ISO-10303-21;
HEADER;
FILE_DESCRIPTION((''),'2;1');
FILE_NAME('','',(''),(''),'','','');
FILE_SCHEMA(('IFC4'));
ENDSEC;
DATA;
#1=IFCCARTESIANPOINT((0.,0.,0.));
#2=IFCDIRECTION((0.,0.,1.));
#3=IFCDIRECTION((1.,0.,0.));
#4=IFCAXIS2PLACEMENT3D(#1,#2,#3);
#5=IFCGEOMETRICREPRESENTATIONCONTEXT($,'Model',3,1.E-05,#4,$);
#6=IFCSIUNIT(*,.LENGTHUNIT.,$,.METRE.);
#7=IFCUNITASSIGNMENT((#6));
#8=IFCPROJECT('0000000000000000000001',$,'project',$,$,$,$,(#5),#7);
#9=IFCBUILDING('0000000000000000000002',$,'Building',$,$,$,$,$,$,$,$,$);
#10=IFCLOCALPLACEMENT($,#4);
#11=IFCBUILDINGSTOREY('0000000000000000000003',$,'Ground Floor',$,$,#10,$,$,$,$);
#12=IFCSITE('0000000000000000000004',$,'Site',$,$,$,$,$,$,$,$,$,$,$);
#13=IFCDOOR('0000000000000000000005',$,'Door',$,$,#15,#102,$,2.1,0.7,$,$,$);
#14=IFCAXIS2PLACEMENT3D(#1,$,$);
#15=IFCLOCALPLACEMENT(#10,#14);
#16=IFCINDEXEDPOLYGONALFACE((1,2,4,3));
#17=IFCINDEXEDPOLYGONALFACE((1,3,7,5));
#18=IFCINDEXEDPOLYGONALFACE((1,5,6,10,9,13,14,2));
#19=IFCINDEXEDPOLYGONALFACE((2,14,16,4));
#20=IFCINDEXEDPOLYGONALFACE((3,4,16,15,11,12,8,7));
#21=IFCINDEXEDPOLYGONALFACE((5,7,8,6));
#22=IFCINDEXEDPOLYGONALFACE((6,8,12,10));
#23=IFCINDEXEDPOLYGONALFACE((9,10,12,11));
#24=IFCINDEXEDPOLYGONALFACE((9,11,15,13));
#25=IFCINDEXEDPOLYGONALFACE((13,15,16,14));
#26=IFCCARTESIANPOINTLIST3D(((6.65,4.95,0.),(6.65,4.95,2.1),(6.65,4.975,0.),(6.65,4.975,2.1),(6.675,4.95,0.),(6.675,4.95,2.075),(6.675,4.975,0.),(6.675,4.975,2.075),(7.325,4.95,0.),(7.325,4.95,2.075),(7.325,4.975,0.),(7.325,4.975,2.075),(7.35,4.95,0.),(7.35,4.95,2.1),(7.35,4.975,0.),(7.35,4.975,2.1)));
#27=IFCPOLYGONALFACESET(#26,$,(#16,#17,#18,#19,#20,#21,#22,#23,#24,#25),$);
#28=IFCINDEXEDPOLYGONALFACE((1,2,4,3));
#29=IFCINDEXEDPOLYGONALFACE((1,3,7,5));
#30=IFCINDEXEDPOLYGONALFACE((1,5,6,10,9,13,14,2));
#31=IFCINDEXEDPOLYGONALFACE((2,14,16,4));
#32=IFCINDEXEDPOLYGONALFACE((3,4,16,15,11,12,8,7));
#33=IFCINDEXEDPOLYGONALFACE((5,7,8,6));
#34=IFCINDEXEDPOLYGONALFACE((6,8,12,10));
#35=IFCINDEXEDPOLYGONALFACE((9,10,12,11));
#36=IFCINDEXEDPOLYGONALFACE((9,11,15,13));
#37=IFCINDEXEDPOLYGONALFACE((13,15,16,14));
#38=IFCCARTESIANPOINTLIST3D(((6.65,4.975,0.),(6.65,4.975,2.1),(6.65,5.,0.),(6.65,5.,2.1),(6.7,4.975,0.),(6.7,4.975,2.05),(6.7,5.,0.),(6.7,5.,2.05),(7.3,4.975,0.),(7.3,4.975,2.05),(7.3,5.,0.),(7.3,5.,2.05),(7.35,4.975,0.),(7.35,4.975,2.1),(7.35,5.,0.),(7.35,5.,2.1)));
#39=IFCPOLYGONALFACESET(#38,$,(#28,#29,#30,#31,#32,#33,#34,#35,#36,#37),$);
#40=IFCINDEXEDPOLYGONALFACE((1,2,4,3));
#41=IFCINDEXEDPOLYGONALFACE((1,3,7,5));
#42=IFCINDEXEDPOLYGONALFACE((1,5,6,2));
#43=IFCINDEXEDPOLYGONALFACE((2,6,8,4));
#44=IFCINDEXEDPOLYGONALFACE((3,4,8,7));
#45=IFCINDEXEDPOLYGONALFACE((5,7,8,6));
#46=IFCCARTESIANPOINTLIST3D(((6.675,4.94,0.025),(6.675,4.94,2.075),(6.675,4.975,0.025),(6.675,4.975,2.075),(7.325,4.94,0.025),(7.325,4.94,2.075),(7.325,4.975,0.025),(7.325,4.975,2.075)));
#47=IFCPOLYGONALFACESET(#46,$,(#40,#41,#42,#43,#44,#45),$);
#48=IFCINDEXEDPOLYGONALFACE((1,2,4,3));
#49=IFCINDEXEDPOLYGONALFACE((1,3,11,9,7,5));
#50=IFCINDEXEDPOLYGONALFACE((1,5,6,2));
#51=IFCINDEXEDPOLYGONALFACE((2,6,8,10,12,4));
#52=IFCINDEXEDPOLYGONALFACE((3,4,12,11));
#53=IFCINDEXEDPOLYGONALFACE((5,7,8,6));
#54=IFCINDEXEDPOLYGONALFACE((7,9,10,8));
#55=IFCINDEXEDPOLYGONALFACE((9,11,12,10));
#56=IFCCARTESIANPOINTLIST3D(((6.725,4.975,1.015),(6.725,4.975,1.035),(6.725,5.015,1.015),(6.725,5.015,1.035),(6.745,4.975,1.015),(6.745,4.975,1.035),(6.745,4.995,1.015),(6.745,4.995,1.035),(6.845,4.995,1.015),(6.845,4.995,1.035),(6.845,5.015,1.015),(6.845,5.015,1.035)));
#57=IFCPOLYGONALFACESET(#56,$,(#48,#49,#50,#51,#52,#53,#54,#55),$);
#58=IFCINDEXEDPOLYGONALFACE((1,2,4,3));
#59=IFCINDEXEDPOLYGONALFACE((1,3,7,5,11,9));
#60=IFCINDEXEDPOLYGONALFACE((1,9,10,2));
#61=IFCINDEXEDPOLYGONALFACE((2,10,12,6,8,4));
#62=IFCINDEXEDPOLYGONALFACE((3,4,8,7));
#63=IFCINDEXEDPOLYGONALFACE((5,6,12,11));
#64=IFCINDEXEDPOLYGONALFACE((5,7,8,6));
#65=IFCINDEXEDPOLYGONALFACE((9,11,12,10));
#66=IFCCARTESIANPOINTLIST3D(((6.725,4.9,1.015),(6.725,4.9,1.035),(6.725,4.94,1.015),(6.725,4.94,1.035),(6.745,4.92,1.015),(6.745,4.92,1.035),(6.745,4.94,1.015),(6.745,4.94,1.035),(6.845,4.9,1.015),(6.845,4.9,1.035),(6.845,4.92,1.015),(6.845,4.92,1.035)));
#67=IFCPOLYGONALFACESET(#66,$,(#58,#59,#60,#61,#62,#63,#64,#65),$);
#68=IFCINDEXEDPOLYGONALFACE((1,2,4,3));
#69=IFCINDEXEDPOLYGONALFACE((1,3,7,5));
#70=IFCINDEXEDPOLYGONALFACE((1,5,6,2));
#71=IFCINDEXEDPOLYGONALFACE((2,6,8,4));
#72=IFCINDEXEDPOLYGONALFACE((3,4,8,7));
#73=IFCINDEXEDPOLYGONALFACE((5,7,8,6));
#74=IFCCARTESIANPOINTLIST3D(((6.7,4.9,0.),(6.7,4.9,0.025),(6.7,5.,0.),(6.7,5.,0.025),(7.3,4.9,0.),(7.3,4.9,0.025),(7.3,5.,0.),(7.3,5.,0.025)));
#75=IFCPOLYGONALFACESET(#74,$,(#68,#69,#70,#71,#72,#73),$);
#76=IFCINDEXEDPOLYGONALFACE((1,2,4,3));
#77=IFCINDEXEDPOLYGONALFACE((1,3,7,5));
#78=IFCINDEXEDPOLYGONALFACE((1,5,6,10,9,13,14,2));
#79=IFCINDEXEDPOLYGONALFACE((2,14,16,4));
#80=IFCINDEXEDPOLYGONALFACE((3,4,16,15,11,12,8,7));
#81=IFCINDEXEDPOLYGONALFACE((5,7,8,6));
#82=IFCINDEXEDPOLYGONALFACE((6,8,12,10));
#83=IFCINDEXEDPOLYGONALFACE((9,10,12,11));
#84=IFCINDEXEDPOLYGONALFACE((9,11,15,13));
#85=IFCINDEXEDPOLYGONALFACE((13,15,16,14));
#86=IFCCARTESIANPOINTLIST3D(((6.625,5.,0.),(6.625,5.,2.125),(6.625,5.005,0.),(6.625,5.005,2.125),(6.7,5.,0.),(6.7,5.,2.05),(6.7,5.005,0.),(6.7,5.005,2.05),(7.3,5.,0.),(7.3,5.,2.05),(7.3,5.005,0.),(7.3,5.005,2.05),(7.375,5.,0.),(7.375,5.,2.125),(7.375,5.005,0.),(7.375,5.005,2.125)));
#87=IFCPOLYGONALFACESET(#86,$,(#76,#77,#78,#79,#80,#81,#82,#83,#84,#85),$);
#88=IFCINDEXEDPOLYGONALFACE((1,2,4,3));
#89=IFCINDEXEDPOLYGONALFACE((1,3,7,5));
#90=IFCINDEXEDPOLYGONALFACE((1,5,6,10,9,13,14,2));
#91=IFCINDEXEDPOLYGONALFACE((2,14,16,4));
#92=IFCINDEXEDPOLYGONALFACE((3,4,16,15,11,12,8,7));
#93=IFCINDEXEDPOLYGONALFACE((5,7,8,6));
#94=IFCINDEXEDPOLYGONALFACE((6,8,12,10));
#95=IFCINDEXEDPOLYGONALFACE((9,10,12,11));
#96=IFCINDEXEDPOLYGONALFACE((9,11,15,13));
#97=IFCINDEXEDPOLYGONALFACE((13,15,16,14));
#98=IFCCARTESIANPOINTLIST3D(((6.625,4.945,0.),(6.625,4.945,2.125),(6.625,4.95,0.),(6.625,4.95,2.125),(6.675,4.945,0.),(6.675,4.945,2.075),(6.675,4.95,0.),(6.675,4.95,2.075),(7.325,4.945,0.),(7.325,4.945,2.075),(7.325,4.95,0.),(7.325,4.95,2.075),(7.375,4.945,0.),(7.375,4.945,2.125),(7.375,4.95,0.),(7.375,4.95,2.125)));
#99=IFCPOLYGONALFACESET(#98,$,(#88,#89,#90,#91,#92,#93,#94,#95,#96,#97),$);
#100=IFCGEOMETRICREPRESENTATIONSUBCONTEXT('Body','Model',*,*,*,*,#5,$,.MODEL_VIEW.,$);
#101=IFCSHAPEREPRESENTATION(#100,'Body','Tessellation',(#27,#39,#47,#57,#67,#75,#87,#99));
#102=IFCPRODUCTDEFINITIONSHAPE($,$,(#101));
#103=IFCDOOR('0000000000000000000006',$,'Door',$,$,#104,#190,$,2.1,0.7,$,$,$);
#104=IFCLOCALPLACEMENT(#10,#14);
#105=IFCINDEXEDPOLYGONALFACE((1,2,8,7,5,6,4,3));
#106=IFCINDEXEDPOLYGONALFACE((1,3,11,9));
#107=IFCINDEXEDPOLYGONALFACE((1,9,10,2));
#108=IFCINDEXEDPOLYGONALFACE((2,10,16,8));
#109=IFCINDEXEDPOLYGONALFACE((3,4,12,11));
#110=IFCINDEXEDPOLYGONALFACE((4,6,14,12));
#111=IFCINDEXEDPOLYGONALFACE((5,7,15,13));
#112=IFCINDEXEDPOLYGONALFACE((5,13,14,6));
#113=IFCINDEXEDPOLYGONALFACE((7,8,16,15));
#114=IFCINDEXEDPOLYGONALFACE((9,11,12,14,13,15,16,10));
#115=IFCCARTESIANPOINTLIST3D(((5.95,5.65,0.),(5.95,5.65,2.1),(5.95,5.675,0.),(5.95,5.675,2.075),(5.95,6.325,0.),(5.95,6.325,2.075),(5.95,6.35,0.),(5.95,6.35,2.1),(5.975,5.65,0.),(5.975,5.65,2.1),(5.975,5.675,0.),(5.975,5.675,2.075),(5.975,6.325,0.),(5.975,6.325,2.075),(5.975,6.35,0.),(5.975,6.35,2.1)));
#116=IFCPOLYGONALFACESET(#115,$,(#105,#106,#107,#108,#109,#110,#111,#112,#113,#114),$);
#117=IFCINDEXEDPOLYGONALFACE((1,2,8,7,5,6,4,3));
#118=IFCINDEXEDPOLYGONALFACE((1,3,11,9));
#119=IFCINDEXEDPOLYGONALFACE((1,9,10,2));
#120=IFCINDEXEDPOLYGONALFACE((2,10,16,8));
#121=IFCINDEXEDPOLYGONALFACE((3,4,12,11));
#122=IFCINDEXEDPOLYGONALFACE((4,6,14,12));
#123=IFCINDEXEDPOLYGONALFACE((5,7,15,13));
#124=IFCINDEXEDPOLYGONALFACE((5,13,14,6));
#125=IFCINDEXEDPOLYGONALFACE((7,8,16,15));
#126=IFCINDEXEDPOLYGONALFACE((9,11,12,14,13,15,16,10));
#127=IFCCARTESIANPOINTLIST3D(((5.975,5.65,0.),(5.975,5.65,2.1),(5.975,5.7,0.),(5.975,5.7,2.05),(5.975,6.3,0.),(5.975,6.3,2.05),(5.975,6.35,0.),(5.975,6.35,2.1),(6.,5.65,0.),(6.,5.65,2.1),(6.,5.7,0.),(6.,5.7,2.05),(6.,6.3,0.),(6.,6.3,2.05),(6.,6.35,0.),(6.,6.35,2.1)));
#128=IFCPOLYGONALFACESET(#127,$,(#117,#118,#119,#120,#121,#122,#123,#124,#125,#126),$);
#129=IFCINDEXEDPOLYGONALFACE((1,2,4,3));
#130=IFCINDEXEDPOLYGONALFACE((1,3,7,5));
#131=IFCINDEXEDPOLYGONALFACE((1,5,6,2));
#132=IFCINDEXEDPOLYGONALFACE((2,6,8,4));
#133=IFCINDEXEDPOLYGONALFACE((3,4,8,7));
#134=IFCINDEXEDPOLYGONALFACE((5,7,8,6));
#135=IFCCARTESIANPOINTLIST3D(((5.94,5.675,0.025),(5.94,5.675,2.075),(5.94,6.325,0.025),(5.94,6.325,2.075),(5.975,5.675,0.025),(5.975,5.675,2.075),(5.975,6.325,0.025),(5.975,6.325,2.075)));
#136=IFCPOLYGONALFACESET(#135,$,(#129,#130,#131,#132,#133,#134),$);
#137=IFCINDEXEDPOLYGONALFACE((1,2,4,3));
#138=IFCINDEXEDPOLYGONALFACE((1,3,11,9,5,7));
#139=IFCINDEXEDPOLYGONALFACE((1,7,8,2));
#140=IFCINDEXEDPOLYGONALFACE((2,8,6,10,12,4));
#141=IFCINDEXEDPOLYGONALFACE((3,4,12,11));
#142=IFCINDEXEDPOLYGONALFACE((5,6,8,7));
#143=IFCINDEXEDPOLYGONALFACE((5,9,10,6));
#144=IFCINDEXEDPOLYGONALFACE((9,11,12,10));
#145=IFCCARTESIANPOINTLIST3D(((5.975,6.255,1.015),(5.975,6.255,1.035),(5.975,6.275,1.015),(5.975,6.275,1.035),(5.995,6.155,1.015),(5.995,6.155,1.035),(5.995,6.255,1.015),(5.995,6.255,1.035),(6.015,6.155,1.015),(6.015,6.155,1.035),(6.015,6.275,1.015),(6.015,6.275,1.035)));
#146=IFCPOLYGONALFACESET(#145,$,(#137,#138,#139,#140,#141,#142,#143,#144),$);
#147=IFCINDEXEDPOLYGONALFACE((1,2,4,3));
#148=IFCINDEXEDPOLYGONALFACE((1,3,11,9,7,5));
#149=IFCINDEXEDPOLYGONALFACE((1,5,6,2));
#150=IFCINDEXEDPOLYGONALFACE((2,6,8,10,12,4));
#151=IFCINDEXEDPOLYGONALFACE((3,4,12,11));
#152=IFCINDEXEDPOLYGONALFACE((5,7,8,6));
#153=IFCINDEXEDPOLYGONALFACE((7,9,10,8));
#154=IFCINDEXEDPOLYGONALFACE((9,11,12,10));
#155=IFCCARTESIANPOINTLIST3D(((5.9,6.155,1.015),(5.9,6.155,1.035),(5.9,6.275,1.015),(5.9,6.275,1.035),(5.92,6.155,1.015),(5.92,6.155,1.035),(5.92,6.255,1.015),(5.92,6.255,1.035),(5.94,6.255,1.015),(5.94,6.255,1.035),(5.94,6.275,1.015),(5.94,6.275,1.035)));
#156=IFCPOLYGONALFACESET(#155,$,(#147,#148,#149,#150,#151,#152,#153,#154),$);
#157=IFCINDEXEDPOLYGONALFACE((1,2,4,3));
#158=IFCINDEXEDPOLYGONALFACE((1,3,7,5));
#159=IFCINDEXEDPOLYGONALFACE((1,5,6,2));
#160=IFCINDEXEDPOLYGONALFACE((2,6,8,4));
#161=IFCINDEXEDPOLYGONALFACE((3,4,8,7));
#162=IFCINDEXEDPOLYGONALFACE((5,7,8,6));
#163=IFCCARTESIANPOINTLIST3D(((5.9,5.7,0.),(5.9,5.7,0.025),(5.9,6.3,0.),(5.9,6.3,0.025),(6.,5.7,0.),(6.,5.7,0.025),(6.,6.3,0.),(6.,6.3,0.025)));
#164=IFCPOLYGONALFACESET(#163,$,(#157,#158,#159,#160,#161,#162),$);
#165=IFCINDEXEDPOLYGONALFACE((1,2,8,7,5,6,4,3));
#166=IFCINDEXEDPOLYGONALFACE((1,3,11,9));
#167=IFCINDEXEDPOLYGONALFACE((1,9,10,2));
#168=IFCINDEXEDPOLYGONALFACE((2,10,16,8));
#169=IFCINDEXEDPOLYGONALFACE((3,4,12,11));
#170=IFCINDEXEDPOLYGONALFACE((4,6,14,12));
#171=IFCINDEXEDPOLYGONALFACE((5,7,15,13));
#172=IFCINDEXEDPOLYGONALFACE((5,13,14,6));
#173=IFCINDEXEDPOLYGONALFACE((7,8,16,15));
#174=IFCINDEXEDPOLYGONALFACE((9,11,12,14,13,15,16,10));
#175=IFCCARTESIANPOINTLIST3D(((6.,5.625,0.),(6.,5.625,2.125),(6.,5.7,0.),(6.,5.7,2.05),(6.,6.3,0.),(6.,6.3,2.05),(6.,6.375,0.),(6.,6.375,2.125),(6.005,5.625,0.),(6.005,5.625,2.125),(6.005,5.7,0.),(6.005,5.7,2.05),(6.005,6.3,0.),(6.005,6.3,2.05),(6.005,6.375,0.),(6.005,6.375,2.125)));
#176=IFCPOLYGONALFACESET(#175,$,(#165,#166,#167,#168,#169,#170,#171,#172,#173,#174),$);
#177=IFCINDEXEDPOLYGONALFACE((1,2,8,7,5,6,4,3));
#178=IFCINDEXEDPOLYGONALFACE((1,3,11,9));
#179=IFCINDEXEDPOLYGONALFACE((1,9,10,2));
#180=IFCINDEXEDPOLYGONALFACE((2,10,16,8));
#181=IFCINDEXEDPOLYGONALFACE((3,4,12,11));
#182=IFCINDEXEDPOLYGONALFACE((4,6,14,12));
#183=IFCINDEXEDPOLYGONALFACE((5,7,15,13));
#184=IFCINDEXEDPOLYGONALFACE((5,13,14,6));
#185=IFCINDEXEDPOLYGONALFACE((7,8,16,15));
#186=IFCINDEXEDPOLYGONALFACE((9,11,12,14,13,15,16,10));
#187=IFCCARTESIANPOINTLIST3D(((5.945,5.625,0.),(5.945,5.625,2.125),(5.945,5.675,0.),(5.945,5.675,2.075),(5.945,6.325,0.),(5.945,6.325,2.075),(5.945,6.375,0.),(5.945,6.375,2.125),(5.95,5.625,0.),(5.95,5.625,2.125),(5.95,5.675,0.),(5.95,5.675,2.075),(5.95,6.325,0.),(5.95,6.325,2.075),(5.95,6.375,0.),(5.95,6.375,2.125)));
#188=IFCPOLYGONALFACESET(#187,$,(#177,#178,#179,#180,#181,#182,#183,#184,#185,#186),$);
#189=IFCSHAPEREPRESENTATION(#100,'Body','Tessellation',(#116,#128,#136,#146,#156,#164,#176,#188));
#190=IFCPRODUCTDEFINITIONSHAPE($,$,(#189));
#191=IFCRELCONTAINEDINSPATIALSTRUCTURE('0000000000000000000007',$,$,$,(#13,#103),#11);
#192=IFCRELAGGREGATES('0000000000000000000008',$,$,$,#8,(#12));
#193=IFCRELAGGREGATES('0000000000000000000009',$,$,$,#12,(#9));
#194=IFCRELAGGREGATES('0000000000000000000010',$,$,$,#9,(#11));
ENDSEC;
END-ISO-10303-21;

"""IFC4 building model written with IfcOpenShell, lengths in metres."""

from ifc_helpers import new_model, si_unit, frame, origin_with_axes, place, context, subcontext, project, spatial, line, indexed_curve, outline, extrude, element, save


model = new_model("IFC4")

# Units and contexts
model_context = context("Model", 3, precision=1e-05, world=origin_with_axes())
body_context = subcontext(model_context, "Body", "Model", "MODEL_VIEW")
ifc_project = project(units=[si_unit("LENGTHUNIT", "METRE")], contexts=[model_context])

# Site, building, storey
site = spatial("IfcSite", under=ifc_project, Name="Site")
building = spatial("IfcBuilding", under=site, Name="Building")
storey_placement = place(None, origin_with_axes())
storey = spatial("IfcBuildingStorey", under=building, at=storey_placement, Name="Ground Floor")

# Doors
door_1_placement = place(storey_placement, frame((7.35, 5.0, 0.0), z_axis=(0.0, 0.0, 1.0), x_axis=(-1.0, 0.0, 0.0)))
element("IfcDoor", 1, at=door_1_placement, inside=storey, Name="Door", OverallHeight=2.1, OverallWidth=0.7, context=body_context, shape_type="SweptSolid", body=[
    extrude(outline(indexed_curve([(0.0, 0.0), (0.0, 2.1), (0.7, 2.1), (0.7, 0.0), (0.675, 0.0), (0.675, 2.075), (0.025, 2.075), (0.025, 0.0)], segments=[line(1, 2, 3, 4, 5, 6, 7, 8, 1)])), frame((0.0, 0.025, 0.0), z_axis=(0.0, -1.0, 0.0), x_axis=(1.0, 0.0, 0.0)), (0.0, 0.0, -1.0), 0.025),
    extrude(outline(indexed_curve([(0.0, 0.0), (0.0, 2.1), (0.7, 2.1), (0.7, 0.0), (0.65, 0.0), (0.65, 2.05), (0.05, 2.05), (0.05, 0.0)], segments=[line(1, 2, 3, 4, 5, 6, 7, 8, 1)])), frame((0.0, 0.0, 0.0), z_axis=(0.0, -1.0, 0.0), x_axis=(1.0, 0.0, 0.0)), (0.0, 0.0, -1.0), 0.025),
    extrude(outline(indexed_curve([(0.0, 0.0), (0.65, 0.0), (0.65, 0.035), (0.0, 0.035)], segments=[line(1, 2, 3, 4, 1)])), frame((0.025, 0.025, 0.025), z_axis=(0.0, 0.0, 1.0), x_axis=(1.0, 0.0, 0.0)), (0.0, 0.0, 1.0), 2.05),
    extrude(outline(indexed_curve([(0.0, 0.0), (0.0, -0.04), (-0.12, -0.04), (-0.12, -0.02), (-0.02, -0.02), (-0.02, 0.0)], segments=[line(1, 2, 3, 4, 5, 6, 1)])), frame((0.625, 0.025, 1.015), z_axis=(0.0, 0.0, 1.0), x_axis=(1.0, 0.0, 0.0)), (0.0, 0.0, 1.0), 0.02),
    extrude(outline(indexed_curve([(0.0, 0.0), (0.0, 0.04), (-0.12, 0.04), (-0.12, 0.02), (-0.02, 0.02), (-0.02, 0.0)], segments=[line(1, 2, 3, 4, 5, 6, 1)])), frame((0.625, 0.06, 1.015), z_axis=(0.0, 0.0, 1.0), x_axis=(1.0, 0.0, 0.0)), (0.0, 0.0, 1.0), 0.02),
    extrude(outline(indexed_curve([(0.0, 0.0), (0.6, 0.0), (0.6, 0.1), (0.0, 0.1)], segments=[line(1, 2, 3, 4, 1)])), frame((0.05, 0.0, 0.0), z_axis=(0.0, 0.0, 1.0), x_axis=(1.0, 0.0, 0.0)), (0.0, 0.0, 1.0), 0.025),
    extrude(outline(indexed_curve([(0.0, 0.0), (0.0, 2.125), (0.75, 2.125), (0.75, 0.0), (0.675, 0.0), (0.675, 2.05), (0.075, 2.05), (0.075, 0.0)], segments=[line(1, 2, 3, 4, 5, 6, 7, 8, 1)])), frame((-0.025, -0.005, 0.0), z_axis=(0.0, -1.0, 0.0), x_axis=(1.0, 0.0, 0.0)), (0.0, 0.0, -1.0), 0.005),
    extrude(outline(indexed_curve([(0.0, 0.0), (0.0, 2.125), (0.75, 2.125), (0.75, 0.0), (0.7, 0.0), (0.7, 2.075), (0.05, 2.075), (0.05, 0.0)], segments=[line(1, 2, 3, 4, 5, 6, 7, 8, 1)])), frame((-0.025, 0.05, 0.0), z_axis=(0.0, -1.0, 0.0), x_axis=(1.0, 0.0, 0.0)), (0.0, 0.0, -1.0), 0.005),
])
door_2_placement = place(storey_placement, frame((6.0, 5.65, 0.0), z_axis=(0.0, 0.0, 1.0), x_axis=(0.0, 1.0, 0.0)))
element("IfcDoor", 2, at=door_2_placement, inside=storey, Name="Door", OverallHeight=2.1, OverallWidth=0.7, context=body_context, shape_type="SweptSolid", body=[
    extrude(outline(indexed_curve([(0.0, 0.0), (0.0, 2.1), (0.7, 2.1), (0.7, 0.0), (0.675, 0.0), (0.675, 2.075), (0.025, 2.075), (0.025, 0.0)], segments=[line(1, 2, 3, 4, 5, 6, 7, 8, 1)])), frame((0.0, 0.025, 0.0), z_axis=(0.0, -1.0, 0.0), x_axis=(1.0, 0.0, 0.0)), (0.0, 0.0, -1.0), 0.025),
    extrude(outline(indexed_curve([(0.0, 0.0), (0.0, 2.1), (0.7, 2.1), (0.7, 0.0), (0.65, 0.0), (0.65, 2.05), (0.05, 2.05), (0.05, 0.0)], segments=[line(1, 2, 3, 4, 5, 6, 7, 8, 1)])), frame((0.0, 0.0, 0.0), z_axis=(0.0, -1.0, 0.0), x_axis=(1.0, 0.0, 0.0)), (0.0, 0.0, -1.0), 0.025),
    extrude(outline(indexed_curve([(0.0, 0.0), (0.65, 0.0), (0.65, 0.035), (0.0, 0.035)], segments=[line(1, 2, 3, 4, 1)])), frame((0.025, 0.025, 0.025), z_axis=(0.0, 0.0, 1.0), x_axis=(1.0, 0.0, 0.0)), (0.0, 0.0, 1.0), 2.05),
    extrude(outline(indexed_curve([(0.0, 0.0), (0.0, -0.04), (-0.12, -0.04), (-0.12, -0.02), (-0.02, -0.02), (-0.02, 0.0)], segments=[line(1, 2, 3, 4, 5, 6, 1)])), frame((0.625, 0.025, 1.015), z_axis=(0.0, 0.0, 1.0), x_axis=(1.0, 0.0, 0.0)), (0.0, 0.0, 1.0), 0.02),
    extrude(outline(indexed_curve([(0.0, 0.0), (0.0, 0.04), (-0.12, 0.04), (-0.12, 0.02), (-0.02, 0.02), (-0.02, 0.0)], segments=[line(1, 2, 3, 4, 5, 6, 1)])), frame((0.625, 0.06, 1.015), z_axis=(0.0, 0.0, 1.0), x_axis=(1.0, 0.0, 0.0)), (0.0, 0.0, 1.0), 0.02),
    extrude(outline(indexed_curve([(0.0, 0.0), (0.6, 0.0), (0.6, 0.1), (0.0, 0.1)], segments=[line(1, 2, 3, 4, 1)])), frame((0.05, 0.0, 0.0), z_axis=(0.0, 0.0, 1.0), x_axis=(1.0, 0.0, 0.0)), (0.0, 0.0, 1.0), 0.025),
    extrude(outline(indexed_curve([(0.0, 0.0), (0.0, 2.125), (0.75, 2.125), (0.75, 0.0), (0.675, 0.0), (0.675, 2.05), (0.075, 2.05), (0.075, 0.0)], segments=[line(1, 2, 3, 4, 5, 6, 7, 8, 1)])), frame((-0.025, -0.005, 0.0), z_axis=(0.0, -1.0, 0.0), x_axis=(1.0, 0.0, 0.0)), (0.0, 0.0, -1.0), 0.005),
    extrude(outline(indexed_curve([(0.0, 0.0), (0.0, 2.125), (0.75, 2.125), (0.75, 0.0), (0.7, 0.0), (0.7, 2.075), (0.05, 2.075), (0.05, 0.0)], segments=[line(1, 2, 3, 4, 5, 6, 7, 8, 1)])), frame((-0.025, 0.05, 0.0), z_axis=(0.0, -1.0, 0.0), x_axis=(1.0, 0.0, 0.0)), (0.0, 0.0, -1.0), 0.005),
])

save(model, "model.ifc")
